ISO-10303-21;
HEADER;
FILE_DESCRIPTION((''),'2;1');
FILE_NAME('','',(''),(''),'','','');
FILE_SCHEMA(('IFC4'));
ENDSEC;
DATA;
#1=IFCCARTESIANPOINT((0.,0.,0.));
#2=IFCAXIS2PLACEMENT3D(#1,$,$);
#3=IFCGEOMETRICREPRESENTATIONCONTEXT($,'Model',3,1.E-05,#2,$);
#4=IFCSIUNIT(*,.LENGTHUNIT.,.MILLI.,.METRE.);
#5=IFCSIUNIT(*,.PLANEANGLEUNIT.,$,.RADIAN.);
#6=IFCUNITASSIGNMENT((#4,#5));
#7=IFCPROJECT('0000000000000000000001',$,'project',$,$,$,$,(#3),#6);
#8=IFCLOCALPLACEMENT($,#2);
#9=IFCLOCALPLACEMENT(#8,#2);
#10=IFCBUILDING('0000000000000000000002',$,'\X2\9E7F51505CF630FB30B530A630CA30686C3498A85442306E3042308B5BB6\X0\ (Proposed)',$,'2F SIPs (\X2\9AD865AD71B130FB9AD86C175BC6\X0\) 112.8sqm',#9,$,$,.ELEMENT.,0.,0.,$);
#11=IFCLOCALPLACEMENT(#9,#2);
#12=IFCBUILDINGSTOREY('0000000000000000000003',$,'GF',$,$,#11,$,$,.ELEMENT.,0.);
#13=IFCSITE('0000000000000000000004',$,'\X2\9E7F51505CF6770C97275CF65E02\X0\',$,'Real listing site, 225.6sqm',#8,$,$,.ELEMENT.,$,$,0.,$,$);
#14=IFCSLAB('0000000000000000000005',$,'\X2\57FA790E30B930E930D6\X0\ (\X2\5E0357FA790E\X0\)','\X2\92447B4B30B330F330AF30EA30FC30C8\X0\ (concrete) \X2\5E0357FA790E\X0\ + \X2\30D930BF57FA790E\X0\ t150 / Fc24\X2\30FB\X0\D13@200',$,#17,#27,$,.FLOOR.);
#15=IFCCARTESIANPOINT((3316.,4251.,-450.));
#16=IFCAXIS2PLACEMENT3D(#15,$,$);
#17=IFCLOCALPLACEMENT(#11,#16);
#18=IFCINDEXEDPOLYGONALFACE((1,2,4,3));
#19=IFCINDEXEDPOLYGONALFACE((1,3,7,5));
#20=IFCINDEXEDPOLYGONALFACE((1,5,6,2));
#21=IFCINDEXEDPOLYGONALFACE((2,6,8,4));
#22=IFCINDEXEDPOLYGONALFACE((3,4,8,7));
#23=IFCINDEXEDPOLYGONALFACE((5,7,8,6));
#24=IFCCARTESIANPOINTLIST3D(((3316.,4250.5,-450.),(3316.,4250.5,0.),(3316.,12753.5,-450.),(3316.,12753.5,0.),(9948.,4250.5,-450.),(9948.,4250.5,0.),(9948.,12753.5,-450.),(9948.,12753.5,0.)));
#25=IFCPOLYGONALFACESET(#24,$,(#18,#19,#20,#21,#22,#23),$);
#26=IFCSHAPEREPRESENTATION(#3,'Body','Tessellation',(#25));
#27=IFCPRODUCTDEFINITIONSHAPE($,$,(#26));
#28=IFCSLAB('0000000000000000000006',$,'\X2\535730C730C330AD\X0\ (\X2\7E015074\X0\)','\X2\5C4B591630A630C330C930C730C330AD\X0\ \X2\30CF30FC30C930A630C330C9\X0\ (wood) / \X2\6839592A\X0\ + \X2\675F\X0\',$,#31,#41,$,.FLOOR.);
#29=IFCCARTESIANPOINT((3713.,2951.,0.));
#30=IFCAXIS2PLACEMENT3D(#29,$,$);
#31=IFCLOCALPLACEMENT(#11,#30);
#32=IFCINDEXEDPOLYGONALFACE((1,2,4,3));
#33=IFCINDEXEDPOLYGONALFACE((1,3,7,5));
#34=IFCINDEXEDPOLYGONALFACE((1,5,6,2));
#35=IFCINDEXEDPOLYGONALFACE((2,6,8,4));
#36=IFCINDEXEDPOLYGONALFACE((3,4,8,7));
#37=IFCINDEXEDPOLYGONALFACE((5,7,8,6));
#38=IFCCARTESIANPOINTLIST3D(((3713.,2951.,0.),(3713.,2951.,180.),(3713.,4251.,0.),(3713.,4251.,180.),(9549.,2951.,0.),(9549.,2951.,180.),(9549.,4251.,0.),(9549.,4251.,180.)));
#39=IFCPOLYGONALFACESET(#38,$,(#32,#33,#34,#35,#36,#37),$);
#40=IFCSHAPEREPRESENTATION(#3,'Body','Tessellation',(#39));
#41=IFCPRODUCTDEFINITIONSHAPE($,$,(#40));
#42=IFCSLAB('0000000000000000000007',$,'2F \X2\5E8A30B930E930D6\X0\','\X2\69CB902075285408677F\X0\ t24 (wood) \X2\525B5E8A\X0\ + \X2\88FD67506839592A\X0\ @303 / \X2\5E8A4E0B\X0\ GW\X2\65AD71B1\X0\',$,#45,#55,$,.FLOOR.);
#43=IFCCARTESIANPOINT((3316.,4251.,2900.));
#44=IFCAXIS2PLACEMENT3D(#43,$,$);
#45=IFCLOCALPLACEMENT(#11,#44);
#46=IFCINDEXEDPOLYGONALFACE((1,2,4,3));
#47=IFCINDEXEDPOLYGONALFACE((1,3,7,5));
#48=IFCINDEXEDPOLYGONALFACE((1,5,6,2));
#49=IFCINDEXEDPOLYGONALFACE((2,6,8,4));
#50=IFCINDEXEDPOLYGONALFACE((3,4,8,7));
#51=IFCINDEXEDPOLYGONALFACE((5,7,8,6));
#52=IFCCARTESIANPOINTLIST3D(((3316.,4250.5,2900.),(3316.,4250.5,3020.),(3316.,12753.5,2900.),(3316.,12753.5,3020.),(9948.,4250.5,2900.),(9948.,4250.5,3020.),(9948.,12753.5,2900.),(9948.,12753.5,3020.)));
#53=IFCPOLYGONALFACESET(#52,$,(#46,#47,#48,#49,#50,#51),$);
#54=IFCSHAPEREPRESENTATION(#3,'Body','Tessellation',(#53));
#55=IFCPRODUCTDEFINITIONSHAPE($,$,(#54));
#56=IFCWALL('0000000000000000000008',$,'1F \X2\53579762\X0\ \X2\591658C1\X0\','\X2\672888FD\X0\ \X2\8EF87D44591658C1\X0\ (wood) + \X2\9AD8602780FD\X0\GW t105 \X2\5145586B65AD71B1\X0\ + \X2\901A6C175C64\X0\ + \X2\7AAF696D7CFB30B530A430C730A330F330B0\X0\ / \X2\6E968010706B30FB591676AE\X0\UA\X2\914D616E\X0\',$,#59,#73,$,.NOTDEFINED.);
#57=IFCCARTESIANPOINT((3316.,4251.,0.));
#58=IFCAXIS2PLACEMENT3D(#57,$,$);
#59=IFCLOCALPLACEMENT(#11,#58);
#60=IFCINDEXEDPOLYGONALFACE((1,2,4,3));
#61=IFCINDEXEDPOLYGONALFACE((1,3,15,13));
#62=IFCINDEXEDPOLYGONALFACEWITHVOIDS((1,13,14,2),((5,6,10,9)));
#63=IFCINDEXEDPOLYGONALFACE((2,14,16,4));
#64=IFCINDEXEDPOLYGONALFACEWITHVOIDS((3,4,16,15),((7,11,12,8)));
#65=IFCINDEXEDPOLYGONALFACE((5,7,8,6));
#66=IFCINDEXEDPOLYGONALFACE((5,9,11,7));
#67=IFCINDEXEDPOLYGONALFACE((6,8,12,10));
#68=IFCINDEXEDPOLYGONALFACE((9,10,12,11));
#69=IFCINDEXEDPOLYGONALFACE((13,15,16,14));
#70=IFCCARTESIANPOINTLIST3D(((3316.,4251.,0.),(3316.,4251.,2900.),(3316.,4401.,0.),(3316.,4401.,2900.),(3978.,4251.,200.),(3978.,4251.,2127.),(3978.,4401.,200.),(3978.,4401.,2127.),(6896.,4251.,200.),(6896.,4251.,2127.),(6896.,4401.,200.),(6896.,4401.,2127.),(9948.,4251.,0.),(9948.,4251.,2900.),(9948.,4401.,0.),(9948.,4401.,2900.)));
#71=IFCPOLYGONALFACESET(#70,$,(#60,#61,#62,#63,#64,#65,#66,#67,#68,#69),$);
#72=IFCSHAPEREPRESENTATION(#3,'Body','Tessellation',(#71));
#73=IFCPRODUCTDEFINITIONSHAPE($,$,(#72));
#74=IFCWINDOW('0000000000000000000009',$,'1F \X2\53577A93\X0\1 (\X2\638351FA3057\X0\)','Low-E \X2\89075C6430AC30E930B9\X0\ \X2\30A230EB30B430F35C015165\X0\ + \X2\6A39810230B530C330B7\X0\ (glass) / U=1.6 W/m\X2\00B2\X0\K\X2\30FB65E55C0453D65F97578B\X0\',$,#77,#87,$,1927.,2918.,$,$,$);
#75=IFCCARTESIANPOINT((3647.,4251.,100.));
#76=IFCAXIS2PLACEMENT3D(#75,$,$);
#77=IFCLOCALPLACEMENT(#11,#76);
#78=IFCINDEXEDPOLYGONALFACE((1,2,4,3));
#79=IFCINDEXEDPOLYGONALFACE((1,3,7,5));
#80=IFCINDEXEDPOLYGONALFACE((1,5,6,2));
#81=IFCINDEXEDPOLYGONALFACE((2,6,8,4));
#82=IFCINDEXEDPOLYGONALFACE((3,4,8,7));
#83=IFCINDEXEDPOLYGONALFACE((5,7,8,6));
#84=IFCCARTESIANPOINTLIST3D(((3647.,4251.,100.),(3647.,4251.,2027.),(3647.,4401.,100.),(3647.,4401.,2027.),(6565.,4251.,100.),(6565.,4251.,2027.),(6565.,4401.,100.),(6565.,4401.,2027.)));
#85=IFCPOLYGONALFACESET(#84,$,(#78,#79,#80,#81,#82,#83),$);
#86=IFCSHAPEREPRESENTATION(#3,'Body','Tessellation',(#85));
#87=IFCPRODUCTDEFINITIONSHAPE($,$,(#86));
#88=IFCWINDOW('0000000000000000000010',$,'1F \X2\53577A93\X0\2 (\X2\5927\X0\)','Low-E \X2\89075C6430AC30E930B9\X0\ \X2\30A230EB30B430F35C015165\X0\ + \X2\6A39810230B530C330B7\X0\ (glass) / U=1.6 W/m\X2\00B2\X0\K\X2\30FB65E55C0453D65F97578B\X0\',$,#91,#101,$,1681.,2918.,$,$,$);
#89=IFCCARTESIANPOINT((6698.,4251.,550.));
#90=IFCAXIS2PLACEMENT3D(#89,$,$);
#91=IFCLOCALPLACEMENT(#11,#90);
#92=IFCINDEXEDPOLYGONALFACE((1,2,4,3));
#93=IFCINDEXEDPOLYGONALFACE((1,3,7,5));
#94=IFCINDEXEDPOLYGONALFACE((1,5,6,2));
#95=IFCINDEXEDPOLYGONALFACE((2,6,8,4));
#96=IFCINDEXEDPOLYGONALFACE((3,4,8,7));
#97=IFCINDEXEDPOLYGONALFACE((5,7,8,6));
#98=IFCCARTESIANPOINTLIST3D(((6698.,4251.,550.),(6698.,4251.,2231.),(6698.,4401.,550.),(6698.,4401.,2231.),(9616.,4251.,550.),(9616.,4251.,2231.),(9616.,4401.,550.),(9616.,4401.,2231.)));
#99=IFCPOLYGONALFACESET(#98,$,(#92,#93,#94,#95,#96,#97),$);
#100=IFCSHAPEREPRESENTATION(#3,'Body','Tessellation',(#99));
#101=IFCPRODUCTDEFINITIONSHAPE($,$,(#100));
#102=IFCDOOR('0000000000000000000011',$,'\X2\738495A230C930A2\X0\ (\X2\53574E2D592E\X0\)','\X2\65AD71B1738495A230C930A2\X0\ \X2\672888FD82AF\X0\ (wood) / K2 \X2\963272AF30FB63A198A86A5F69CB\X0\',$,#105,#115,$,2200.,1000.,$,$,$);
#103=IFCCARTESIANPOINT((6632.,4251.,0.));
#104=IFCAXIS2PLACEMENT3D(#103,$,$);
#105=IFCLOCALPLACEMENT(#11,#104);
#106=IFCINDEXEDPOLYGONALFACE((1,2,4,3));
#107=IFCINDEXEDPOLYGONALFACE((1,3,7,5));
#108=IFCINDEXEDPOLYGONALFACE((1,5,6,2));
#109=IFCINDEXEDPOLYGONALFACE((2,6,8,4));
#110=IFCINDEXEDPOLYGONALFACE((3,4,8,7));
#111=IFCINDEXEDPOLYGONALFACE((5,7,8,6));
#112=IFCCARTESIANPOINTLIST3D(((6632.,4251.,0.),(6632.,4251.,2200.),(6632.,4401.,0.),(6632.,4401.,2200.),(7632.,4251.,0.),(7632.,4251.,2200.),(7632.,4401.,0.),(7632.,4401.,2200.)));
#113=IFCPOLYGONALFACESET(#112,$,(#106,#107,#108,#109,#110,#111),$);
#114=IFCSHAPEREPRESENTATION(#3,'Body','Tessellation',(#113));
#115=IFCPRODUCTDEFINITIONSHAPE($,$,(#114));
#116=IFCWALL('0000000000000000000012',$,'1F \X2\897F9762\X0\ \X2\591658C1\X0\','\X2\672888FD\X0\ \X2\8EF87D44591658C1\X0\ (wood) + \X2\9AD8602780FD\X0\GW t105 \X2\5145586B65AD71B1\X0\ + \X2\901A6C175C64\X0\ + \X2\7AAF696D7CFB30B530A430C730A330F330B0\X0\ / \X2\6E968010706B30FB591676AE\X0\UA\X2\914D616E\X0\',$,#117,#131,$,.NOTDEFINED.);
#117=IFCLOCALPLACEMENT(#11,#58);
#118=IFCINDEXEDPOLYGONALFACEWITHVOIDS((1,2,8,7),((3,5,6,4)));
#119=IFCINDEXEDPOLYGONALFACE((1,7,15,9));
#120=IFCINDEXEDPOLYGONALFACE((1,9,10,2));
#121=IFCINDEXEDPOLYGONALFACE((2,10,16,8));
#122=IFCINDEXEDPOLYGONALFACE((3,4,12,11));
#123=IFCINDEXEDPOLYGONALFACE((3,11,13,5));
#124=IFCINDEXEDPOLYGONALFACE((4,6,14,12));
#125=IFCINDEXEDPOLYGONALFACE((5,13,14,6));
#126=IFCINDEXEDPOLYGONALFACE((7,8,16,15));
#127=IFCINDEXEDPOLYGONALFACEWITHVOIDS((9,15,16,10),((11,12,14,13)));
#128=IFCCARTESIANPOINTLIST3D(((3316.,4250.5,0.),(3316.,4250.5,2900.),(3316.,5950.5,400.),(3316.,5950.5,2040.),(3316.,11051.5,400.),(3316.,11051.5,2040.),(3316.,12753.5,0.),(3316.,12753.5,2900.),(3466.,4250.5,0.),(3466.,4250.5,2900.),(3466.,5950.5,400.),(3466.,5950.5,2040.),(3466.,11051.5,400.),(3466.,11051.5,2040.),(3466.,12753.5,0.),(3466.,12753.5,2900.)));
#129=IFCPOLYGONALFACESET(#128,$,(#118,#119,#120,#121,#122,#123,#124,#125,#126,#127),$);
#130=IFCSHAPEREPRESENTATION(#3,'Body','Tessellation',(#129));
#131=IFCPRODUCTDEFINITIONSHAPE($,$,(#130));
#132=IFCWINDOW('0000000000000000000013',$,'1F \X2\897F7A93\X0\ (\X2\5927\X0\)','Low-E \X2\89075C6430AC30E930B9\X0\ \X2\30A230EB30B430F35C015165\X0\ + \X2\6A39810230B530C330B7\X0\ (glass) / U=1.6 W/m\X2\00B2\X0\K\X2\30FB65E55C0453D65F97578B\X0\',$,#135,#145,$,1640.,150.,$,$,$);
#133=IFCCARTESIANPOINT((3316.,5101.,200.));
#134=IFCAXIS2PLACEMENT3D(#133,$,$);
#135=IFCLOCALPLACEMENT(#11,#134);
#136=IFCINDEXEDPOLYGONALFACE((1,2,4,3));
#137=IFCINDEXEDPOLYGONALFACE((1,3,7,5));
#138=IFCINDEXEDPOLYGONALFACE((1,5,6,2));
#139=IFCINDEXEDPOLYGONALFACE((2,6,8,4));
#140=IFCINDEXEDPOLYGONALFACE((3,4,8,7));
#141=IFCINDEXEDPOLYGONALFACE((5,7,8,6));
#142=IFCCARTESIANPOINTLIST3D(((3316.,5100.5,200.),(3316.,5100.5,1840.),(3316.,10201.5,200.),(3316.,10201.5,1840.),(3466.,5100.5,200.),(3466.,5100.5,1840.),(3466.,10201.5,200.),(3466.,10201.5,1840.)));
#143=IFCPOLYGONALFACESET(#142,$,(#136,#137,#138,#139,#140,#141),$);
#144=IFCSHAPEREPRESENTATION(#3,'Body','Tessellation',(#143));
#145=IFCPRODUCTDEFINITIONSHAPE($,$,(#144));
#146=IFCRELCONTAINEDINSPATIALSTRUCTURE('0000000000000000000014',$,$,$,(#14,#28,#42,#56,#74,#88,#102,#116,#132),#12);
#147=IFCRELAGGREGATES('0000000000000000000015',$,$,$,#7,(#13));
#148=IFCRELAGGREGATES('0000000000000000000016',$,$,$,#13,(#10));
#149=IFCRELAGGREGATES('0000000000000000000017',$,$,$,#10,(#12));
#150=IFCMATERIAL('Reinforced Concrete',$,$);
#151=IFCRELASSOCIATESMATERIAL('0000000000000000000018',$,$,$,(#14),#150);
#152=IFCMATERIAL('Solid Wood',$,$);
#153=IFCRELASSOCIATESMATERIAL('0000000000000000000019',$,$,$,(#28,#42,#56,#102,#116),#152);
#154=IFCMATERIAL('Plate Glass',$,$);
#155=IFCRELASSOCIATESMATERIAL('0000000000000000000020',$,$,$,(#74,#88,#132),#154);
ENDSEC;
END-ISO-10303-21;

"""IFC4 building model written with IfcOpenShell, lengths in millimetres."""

from ifc_helpers import new_model, si_unit, frame, frame_2d, origin, place, context, project, spatial, rectangle, extrude, material, element, fill, save


model = new_model("IFC4")

# Units and contexts
model_context = context("Model", 3, precision=1e-05, world=origin())
ifc_project = project(units=[si_unit("LENGTHUNIT", "METRE", prefix="MILLI"), si_unit("PLANEANGLEUNIT", "RADIAN")], contexts=[model_context])

# Site, building, storey
site_placement = place(None, origin())
site = spatial("IfcSite", under=ifc_project, at=site_placement, Name="鹿児島県霧島市", ObjectType="Real listing site, 225.6sqm", CompositionType="ELEMENT", RefElevation=0.0)
building_placement = place(site_placement, origin())
building = spatial("IfcBuilding", under=site, at=building_placement, Name="鹿児島・サウナと水風呂のある家 (Proposed)", ObjectType="2F SIPs (高断熱・高気密) 112.8sqm", CompositionType="ELEMENT", ElevationOfRefHeight=0.0, ElevationOfTerrain=0.0)
storey_placement = place(building_placement, origin())
storey = spatial("IfcBuildingStorey", under=building, at=storey_placement, Name="GF", CompositionType="ELEMENT", Elevation=0.0)

# Slabs
ifc_material_1 = material(Name="Reinforced Concrete")
slab_1_placement = place(storey_placement, frame((3316.0, 4251.0, -450.0)))
element("IfcSlab", 1, at=slab_1_placement, inside=storey, material=ifc_material_1, Name="基礎スラブ (布基礎)", Description="鉄筋コンクリート (concrete) 布基礎 + ベタ基礎 t150 / Fc24・D13@200", PredefinedType="FLOOR", context=model_context, shape_type="SweptSolid", body=[
    extrude(rectangle(XDim=6632.0, YDim=8503.0, at=frame_2d((3316.0, 4251.0))), frame((3316.0, 4251.0, -450.0)), (0.0, 0.0, 1.0), 450.0),
])
ifc_material_2 = material(Name="Solid Wood")
slab_2_placement = place(storey_placement, frame((3713.0, 2951.0, 0.0)))
element("IfcSlab", 2, at=slab_2_placement, inside=storey, material=ifc_material_2, Name="南デッキ (縁側)", Description="屋外ウッドデッキ ハードウッド (wood) / 根太 + 束", PredefinedType="FLOOR", context=model_context, shape_type="SweptSolid", body=[
    extrude(rectangle(XDim=5836.0, YDim=1300.0, at=frame_2d((2918.0, 650.0))), frame((3713.0, 2951.0, 0.0)), (0.0, 0.0, 1.0), 180.0),
])
slab_3_placement = place(storey_placement, frame((3316.0, 4251.0, 2900.0)))
element("IfcSlab", 3, at=slab_3_placement, inside=storey, material=ifc_material_2, Name="2F 床スラブ", Description="構造用合板 t24 (wood) 剛床 + 製材根太 @303 / 床下 GW断熱", PredefinedType="FLOOR", context=model_context, shape_type="SweptSolid", body=[
    extrude(rectangle(XDim=6632.0, YDim=8503.0, at=frame_2d((3316.0, 4251.0))), frame((3316.0, 4251.0, 2900.0)), (0.0, 0.0, 1.0), 120.0),
])

# Wall, openings, windows, door
wall_1_placement = place(storey_placement, frame((3316.0, 4251.0, 0.0)))
wall_1 = element("IfcWall", 4, at=wall_1_placement, inside=storey, material=ifc_material_2, Name="1F 南面 外壁", Description="木製 軸組外壁 (wood) + 高性能GW t105 充填断熱 + 通気層 + 窯業系サイディング / 準耐火・外皮UA配慮", PredefinedType="NOTDEFINED", context=model_context, shape_type="SweptSolid", body=[
    extrude(rectangle(XDim=6632.0, YDim=150.0, at=frame_2d((3316.0, 75.0))), frame((3316.0, 4251.0, 0.0)), (0.0, 0.0, 1.0), 2900.0),
])
opening_1_placement = place(storey_placement, frame((3647.0, 4251.0, 100.0)))
opening_1 = element("IfcOpeningElement", 5, at=opening_1_placement, cuts=wall_1, PredefinedType="NOTDEFINED", context=model_context, shape_type="SweptSolid", body=[
    extrude(rectangle(XDim=2918.0, YDim=150.0, at=frame_2d((1459.0, 75.0))), frame((3647.0, 4251.0, 100.0)), (0.0, 0.0, 1.0), 1927.0),
])
opening_2_placement = place(storey_placement, frame((6698.0, 4251.0, 550.0)))
opening_2 = element("IfcOpeningElement", 6, at=opening_2_placement, cuts=wall_1, PredefinedType="NOTDEFINED", context=model_context, shape_type="SweptSolid", body=[
    extrude(rectangle(XDim=2918.0, YDim=150.0, at=frame_2d((1459.0, 75.0))), frame((6698.0, 4251.0, 550.0)), (0.0, 0.0, 1.0), 1681.0),
])
opening_3_placement = place(storey_placement, frame((6632.0, 4251.0, 0.0)))
opening_3 = element("IfcOpeningElement", 7, at=opening_3_placement, cuts=wall_1, PredefinedType="NOTDEFINED", context=model_context, shape_type="SweptSolid", body=[
    extrude(rectangle(XDim=1000.0, YDim=150.0, at=frame_2d((500.0, 75.0))), frame((6632.0, 4251.0, 0.0)), (0.0, 0.0, 1.0), 2200.0),
])
ifc_material_3 = material(Name="Plate Glass")
window_1_placement = place(storey_placement, frame((3647.0, 4251.0, 100.0)))
window_1 = element("IfcWindow", 8, at=window_1_placement, inside=storey, material=ifc_material_3, Name="1F 南窓1 (掃出し)", Description="Low-E 複層ガラス アルゴン封入 + 樹脂サッシ (glass) / U=1.6 W/m²K・日射取得型", OverallHeight=1927.0, OverallWidth=2918.0, context=model_context, shape_type="SweptSolid", body=[
    extrude(rectangle(XDim=2918.0, YDim=150.0, at=frame_2d((1459.0, 75.0))), frame((3647.0, 4251.0, 100.0)), (0.0, 0.0, 1.0), 1927.0),
])
fill(opening_1, window_1)
window_2_placement = place(storey_placement, frame((6698.0, 4251.0, 550.0)))
window_2 = element("IfcWindow", 9, at=window_2_placement, inside=storey, material=ifc_material_3, Name="1F 南窓2 (大)", Description="Low-E 複層ガラス アルゴン封入 + 樹脂サッシ (glass) / U=1.6 W/m²K・日射取得型", OverallHeight=1681.0, OverallWidth=2918.0, context=model_context, shape_type="SweptSolid", body=[
    extrude(rectangle(XDim=2918.0, YDim=150.0, at=frame_2d((1459.0, 75.0))), frame((6698.0, 4251.0, 550.0)), (0.0, 0.0, 1.0), 1681.0),
])
fill(opening_2, window_2)
door_placement = place(storey_placement, frame((6632.0, 4251.0, 0.0)))
door = element("IfcDoor", 10, at=door_placement, inside=storey, material=ifc_material_2, Name="玄関ドア (南中央)", Description="断熱玄関ドア 木製芯 (wood) / K2 防犯・採風機構", OverallHeight=2200.0, OverallWidth=1000.0, context=model_context, shape_type="SweptSolid", body=[
    extrude(rectangle(XDim=1000.0, YDim=150.0, at=frame_2d((500.0, 75.0))), frame((6632.0, 4251.0, 0.0)), (0.0, 0.0, 1.0), 2200.0),
])
fill(opening_3, door)

# Wall, opening, window
wall_2_placement = place(storey_placement, frame((3316.0, 4251.0, 0.0)))
wall_2 = element("IfcWall", 11, at=wall_2_placement, inside=storey, material=ifc_material_2, Name="1F 西面 外壁", Description="木製 軸組外壁 (wood) + 高性能GW t105 充填断熱 + 通気層 + 窯業系サイディング / 準耐火・外皮UA配慮", PredefinedType="NOTDEFINED", context=model_context, shape_type="SweptSolid", body=[
    extrude(rectangle(XDim=150.0, YDim=8503.0, at=frame_2d((75.0, 4251.0))), frame((3316.0, 4251.0, 0.0)), (0.0, 0.0, 1.0), 2900.0),
])
opening_4_placement = place(storey_placement, frame((3316.0, 5101.0, 200.0)))
opening_4 = element("IfcOpeningElement", 12, at=opening_4_placement, cuts=wall_2, PredefinedType="NOTDEFINED", context=model_context, shape_type="SweptSolid", body=[
    extrude(rectangle(XDim=150.0, YDim=5101.0, at=frame_2d((75.0, 2550.0))), frame((3316.0, 5101.0, 200.0)), (0.0, 0.0, 1.0), 1640.0),
])
window_3_placement = place(storey_placement, frame((3316.0, 5101.0, 200.0)))
window_3 = element("IfcWindow", 13, at=window_3_placement, inside=storey, material=ifc_material_3, Name="1F 西窓 (大)", Description="Low-E 複層ガラス アルゴン封入 + 樹脂サッシ (glass) / U=1.6 W/m²K・日射取得型", OverallHeight=1640.0, OverallWidth=150.0, context=model_context, shape_type="SweptSolid", body=[
    extrude(rectangle(XDim=150.0, YDim=5101.0, at=frame_2d((75.0, 2550.0))), frame((3316.0, 5101.0, 200.0)), (0.0, 0.0, 1.0), 1640.0),
])
fill(opening_4, window_3)

save(model, "model.ifc")
